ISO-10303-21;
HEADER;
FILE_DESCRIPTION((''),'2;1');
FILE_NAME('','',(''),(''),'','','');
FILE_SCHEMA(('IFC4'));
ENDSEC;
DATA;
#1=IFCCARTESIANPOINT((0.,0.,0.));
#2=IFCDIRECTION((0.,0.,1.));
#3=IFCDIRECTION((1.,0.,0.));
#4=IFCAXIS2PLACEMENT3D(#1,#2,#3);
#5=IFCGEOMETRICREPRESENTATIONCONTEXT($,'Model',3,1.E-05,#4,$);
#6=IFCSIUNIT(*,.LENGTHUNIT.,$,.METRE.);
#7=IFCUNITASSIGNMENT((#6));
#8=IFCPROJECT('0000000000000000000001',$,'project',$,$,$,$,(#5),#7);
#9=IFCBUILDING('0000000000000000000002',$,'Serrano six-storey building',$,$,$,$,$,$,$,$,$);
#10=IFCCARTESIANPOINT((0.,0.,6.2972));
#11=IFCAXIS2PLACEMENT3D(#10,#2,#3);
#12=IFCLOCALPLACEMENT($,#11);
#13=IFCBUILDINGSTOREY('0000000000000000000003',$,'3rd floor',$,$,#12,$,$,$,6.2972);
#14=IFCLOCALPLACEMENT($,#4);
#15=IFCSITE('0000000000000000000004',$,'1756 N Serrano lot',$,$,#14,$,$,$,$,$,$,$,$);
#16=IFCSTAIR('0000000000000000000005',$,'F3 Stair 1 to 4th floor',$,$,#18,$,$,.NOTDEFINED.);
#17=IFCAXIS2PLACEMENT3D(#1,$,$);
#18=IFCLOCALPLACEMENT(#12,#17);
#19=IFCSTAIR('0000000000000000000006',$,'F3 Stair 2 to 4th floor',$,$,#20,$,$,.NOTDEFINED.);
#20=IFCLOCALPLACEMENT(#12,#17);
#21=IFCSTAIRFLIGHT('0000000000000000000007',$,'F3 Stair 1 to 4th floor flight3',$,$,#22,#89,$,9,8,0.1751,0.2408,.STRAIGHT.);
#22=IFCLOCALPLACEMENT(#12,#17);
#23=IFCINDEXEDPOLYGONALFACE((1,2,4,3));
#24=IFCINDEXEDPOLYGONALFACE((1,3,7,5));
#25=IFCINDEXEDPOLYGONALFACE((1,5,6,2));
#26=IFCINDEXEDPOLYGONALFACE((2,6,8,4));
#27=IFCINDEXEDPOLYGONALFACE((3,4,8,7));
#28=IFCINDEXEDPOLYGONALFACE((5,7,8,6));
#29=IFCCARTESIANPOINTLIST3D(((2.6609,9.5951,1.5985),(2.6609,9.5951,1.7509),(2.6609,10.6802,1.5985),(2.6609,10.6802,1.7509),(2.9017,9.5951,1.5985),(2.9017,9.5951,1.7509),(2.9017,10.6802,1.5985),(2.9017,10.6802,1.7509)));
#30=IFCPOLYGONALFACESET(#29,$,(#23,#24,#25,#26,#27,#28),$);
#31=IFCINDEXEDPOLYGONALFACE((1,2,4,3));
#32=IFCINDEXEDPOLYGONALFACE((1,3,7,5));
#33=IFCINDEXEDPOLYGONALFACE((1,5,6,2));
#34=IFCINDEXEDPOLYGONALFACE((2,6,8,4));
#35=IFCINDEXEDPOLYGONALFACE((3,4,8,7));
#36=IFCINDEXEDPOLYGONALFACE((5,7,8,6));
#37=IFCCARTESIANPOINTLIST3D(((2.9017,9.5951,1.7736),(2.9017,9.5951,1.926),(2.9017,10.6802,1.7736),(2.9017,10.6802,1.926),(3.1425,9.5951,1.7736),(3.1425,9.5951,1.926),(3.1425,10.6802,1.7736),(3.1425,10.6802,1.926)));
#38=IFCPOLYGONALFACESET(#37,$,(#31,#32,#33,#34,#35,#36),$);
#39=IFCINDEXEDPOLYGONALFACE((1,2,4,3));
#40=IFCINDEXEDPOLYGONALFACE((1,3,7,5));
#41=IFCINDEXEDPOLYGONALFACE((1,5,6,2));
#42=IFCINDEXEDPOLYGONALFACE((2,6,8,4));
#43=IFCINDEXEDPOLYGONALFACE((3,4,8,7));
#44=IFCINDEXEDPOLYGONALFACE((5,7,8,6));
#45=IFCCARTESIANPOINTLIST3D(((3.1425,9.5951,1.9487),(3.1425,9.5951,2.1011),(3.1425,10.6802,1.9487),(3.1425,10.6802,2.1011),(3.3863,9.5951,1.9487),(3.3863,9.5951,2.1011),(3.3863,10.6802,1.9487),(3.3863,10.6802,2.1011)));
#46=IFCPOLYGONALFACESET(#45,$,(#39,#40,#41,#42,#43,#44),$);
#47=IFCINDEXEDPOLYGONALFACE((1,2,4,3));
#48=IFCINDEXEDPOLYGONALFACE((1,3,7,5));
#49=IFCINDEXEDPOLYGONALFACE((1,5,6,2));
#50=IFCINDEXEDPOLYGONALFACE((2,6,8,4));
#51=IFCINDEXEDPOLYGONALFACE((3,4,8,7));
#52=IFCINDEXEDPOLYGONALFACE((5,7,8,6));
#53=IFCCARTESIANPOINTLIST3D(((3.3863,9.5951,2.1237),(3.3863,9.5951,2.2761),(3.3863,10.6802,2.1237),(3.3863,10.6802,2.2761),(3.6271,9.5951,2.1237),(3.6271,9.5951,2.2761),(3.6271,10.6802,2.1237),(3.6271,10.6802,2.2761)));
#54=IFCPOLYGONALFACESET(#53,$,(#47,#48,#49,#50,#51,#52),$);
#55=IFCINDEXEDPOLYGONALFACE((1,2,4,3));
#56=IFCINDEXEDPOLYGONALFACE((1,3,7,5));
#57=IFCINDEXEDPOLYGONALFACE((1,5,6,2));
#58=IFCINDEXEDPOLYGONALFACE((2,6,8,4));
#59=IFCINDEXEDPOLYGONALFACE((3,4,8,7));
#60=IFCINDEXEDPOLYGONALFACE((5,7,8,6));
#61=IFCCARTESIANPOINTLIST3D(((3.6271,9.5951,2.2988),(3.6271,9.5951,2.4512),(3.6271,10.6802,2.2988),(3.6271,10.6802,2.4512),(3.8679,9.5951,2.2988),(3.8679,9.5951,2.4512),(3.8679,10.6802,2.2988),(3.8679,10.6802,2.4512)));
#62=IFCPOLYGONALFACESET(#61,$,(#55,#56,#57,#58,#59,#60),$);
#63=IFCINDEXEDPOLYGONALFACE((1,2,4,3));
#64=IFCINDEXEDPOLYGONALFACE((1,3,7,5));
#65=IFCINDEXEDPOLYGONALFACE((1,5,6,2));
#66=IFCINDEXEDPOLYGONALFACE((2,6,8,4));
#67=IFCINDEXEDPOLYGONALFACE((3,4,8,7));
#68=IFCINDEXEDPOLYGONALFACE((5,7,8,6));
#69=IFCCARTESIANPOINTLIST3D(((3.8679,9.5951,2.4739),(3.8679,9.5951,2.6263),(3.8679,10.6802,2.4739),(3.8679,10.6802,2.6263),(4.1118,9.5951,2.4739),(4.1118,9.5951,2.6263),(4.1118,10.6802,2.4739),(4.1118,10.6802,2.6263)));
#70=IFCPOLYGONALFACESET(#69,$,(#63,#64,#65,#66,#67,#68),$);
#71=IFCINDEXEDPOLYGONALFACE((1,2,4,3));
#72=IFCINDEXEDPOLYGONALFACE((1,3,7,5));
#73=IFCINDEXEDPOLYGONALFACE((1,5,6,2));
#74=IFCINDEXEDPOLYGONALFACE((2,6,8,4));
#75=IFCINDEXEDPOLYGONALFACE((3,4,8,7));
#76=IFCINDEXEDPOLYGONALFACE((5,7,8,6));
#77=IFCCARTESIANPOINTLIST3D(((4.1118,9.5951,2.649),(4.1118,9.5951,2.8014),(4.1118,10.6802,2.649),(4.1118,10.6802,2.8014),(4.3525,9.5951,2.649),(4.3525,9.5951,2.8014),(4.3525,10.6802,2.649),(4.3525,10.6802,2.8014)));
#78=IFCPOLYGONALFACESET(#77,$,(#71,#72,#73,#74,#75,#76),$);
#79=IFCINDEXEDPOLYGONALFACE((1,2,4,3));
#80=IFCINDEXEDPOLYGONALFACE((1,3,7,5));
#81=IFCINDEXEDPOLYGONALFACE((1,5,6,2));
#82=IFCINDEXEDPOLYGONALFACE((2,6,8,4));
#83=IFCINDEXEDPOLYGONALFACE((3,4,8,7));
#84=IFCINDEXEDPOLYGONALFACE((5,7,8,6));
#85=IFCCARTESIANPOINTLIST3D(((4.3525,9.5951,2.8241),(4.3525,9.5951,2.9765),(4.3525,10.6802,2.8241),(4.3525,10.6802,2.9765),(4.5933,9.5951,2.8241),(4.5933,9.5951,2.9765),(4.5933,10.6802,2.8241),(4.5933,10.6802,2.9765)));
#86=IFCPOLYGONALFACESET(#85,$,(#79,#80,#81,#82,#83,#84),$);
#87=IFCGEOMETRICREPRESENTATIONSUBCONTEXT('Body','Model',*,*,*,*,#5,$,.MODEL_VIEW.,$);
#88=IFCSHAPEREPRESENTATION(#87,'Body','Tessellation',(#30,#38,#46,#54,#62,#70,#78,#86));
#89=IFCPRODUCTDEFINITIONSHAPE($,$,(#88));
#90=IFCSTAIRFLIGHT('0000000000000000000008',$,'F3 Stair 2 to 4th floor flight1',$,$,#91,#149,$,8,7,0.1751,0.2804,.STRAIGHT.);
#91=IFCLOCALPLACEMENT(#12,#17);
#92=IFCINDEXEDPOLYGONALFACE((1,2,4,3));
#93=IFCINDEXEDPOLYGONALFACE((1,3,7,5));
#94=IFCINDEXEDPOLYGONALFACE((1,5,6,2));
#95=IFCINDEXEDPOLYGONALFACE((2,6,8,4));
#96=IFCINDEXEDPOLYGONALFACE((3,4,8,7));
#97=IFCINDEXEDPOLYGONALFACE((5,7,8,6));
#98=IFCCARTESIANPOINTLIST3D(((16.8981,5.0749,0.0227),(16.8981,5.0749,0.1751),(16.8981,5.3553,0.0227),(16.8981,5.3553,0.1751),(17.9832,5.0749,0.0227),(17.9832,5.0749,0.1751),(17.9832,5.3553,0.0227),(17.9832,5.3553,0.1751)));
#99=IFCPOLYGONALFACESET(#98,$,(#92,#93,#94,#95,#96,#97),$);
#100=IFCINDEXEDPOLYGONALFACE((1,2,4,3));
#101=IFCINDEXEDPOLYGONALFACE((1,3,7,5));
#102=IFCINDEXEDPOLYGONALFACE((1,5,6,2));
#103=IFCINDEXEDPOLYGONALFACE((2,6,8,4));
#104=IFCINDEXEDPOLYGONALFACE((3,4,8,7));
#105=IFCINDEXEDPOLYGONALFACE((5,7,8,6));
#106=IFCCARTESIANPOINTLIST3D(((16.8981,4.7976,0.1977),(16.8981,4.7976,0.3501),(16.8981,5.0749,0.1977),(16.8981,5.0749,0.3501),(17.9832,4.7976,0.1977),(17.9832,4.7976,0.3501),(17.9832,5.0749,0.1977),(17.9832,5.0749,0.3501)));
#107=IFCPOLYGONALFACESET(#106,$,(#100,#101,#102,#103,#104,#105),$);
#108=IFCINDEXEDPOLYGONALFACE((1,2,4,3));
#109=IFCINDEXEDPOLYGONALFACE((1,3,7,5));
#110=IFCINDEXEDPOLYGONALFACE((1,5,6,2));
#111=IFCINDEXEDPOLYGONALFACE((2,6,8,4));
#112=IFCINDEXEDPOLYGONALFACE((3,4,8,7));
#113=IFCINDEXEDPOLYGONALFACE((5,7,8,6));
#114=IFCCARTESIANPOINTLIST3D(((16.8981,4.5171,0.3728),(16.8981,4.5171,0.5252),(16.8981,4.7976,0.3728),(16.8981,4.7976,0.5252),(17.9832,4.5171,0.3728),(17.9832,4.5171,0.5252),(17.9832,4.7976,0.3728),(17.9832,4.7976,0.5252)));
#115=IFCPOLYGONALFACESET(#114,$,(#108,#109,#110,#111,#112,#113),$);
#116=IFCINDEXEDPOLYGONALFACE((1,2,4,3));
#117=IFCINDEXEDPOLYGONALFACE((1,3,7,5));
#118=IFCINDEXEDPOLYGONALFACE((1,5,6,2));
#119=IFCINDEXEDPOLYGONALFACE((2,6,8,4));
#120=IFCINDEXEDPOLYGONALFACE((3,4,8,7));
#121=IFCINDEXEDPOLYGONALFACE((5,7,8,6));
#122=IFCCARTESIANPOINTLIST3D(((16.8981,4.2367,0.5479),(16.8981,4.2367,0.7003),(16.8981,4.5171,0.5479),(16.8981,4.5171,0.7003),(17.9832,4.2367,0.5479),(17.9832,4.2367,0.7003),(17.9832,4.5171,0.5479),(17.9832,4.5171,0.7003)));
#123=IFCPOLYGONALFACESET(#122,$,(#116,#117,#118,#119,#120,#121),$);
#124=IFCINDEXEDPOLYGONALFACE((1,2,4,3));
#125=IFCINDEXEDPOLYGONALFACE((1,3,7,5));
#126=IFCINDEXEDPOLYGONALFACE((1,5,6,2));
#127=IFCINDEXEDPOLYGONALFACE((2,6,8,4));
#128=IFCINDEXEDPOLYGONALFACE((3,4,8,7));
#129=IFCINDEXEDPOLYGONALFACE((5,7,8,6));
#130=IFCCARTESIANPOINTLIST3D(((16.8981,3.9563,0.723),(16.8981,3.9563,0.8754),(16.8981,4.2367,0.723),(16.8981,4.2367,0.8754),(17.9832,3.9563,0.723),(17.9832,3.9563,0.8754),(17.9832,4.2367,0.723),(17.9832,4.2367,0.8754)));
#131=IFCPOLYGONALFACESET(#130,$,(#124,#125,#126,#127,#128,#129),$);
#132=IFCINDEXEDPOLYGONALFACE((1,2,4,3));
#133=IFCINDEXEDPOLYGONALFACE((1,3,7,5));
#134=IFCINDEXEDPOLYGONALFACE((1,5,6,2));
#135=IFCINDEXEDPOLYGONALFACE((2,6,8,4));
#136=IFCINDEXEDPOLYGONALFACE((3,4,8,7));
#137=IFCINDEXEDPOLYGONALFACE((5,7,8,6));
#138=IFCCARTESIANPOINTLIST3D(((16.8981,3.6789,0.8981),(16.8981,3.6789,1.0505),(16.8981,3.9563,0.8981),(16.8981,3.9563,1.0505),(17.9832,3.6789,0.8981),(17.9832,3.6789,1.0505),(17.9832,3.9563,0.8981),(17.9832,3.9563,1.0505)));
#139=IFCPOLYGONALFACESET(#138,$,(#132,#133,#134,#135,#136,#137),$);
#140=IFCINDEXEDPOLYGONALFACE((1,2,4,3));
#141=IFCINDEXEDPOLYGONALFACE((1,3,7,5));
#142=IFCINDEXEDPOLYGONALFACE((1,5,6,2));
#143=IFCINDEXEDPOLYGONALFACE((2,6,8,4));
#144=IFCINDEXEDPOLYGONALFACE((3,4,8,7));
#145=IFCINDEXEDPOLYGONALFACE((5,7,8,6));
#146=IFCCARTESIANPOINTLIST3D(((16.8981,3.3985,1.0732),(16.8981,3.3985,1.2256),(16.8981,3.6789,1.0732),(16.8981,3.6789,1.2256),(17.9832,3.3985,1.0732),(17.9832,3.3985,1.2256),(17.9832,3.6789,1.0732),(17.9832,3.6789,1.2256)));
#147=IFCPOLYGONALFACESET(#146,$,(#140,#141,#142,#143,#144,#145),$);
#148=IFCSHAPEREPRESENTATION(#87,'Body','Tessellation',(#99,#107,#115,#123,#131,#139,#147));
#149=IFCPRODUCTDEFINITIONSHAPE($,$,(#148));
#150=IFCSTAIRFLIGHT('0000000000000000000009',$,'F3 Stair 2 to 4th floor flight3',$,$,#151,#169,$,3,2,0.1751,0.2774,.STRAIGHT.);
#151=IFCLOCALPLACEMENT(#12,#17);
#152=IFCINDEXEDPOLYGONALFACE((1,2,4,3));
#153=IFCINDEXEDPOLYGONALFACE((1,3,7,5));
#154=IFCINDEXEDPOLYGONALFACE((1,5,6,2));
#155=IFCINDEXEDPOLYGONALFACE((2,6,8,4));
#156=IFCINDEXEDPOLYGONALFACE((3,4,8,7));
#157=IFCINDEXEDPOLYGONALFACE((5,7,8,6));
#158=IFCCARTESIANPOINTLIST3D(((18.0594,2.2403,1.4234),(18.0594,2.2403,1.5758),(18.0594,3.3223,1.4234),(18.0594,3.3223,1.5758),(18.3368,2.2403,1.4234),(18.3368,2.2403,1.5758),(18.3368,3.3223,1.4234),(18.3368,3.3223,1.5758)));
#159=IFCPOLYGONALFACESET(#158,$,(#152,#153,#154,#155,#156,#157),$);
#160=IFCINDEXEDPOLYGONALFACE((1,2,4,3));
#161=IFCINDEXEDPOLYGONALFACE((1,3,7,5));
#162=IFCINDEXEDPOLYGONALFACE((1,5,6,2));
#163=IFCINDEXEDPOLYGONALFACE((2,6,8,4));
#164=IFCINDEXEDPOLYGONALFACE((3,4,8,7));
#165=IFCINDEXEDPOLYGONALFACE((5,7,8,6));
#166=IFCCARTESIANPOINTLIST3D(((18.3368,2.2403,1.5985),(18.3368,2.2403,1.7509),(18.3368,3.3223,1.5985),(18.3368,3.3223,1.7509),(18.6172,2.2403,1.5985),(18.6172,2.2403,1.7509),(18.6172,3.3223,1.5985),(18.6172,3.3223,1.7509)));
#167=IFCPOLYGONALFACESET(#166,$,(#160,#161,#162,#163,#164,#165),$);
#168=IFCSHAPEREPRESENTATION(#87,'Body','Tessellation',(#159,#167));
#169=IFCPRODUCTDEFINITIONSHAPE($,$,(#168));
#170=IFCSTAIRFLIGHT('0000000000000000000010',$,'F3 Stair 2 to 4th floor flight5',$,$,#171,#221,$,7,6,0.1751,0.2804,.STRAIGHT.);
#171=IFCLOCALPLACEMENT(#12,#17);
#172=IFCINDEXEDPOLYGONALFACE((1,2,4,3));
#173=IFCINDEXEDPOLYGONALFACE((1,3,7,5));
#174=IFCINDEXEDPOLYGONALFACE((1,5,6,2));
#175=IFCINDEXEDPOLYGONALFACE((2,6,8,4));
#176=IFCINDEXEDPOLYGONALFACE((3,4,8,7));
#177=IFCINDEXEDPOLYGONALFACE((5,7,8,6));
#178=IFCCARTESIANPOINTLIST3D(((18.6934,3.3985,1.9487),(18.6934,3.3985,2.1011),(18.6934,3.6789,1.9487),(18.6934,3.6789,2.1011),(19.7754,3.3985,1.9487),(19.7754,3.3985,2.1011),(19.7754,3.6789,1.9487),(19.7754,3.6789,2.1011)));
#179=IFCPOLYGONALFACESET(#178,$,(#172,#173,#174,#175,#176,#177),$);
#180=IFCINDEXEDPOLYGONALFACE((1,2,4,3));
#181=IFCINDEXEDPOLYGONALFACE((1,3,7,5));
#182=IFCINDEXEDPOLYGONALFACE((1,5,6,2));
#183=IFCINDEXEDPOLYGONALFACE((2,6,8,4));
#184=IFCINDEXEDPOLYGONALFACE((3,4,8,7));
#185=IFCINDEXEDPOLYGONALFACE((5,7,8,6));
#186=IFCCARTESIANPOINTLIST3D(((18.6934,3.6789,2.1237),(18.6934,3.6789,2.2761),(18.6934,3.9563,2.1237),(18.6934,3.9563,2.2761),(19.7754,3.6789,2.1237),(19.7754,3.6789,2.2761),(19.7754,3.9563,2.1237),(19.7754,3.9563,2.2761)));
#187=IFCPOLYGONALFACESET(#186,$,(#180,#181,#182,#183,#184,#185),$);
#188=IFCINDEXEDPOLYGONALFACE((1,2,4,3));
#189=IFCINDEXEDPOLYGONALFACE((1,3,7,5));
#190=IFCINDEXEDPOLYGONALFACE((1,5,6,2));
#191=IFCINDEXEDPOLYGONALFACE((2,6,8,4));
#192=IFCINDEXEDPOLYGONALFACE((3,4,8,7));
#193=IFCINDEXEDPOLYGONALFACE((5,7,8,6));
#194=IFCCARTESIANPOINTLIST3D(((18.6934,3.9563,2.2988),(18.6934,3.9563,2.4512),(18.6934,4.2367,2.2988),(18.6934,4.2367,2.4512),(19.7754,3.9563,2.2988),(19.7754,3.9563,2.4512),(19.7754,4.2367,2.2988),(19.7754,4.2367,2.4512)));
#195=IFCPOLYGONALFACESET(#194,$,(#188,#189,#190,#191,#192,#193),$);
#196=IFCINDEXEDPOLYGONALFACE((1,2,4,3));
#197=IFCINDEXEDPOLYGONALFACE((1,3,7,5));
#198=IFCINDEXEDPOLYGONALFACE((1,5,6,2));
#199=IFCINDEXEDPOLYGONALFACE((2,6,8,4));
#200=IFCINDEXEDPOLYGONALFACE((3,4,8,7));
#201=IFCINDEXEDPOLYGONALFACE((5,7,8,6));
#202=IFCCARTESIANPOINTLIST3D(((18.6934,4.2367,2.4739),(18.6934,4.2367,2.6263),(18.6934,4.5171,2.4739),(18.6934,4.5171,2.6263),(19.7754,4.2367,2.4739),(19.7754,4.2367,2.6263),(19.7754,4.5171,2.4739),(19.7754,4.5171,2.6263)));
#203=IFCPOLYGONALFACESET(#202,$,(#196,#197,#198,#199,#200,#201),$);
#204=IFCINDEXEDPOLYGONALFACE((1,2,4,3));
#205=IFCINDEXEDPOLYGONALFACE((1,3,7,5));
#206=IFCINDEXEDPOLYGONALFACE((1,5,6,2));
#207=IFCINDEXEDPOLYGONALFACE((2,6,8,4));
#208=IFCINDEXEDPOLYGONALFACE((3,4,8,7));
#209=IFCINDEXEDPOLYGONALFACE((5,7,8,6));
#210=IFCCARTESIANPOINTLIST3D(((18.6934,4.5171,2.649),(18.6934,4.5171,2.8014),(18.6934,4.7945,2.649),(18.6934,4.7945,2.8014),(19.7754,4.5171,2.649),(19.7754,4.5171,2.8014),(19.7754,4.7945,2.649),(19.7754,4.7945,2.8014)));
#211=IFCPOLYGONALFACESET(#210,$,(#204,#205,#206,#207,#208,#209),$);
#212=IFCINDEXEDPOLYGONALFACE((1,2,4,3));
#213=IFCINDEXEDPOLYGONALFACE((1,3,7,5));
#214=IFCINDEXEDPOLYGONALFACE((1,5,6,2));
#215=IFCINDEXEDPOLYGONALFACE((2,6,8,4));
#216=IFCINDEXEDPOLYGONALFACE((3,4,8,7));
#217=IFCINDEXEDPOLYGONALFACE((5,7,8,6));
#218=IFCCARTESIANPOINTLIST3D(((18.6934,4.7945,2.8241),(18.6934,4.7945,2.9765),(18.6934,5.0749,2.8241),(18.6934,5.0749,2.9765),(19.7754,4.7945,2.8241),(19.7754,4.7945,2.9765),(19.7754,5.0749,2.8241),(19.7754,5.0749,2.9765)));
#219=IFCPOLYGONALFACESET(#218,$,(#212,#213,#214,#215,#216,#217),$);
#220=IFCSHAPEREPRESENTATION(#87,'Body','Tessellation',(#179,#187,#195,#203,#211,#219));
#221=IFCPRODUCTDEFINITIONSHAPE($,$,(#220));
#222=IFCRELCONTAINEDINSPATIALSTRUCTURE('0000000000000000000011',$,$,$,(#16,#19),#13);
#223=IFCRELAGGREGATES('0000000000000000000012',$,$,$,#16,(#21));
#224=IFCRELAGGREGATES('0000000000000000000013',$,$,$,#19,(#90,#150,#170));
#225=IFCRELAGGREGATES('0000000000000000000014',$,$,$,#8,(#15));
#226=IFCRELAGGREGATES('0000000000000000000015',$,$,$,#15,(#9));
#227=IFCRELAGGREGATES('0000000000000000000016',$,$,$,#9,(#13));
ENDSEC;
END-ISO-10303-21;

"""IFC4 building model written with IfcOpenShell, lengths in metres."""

from ifc_helpers import new_model, si_unit, frame, origin_with_axes, place, context, subcontext, project, spatial, polyline, outline, extrude, element, aggregate, save


model = new_model("IFC4")

# Units and contexts
model_context = context("Model", 3, precision=1e-05, world=origin_with_axes())
body_context = subcontext(model_context, "Body", "Model", "MODEL_VIEW")
ifc_project = project(units=[si_unit("LENGTHUNIT", "METRE")], contexts=[model_context])

# Site, building, storey
site_placement = place(None, origin_with_axes())
site = spatial("IfcSite", under=ifc_project, at=site_placement, Name="1756 N Serrano lot")
building = spatial("IfcBuilding", under=site, Name="Serrano six-storey building")
storey_placement = place(None, frame((0.0, 0.0, 6.2972), z_axis=(0.0, 0.0, 1.0), x_axis=(1.0, 0.0, 0.0)))
storey = spatial("IfcBuildingStorey", under=building, at=storey_placement, Name="3rd floor", Elevation=6.2972)

# Stair
stair_1 = element("IfcStair", 1, inside=storey, Name="F3 Stair 1 to 4th floor", PredefinedType="NOTDEFINED")

# Stair
stair_2 = element("IfcStair", 2, inside=storey, Name="F3 Stair 2 to 4th floor", PredefinedType="NOTDEFINED")

# Stair flights
stair_flight_1_placement = place(None, origin_with_axes())
stair_flight_1 = element("IfcStairFlight", 3, at=stair_flight_1_placement, Name="F3 Stair 1 to 4th floor flight3", NumberOfRisers=9, NumberOfTreads=8, PredefinedType="STRAIGHT", RiserHeight=0.1751, TreadLength=0.2408, context=body_context, shape_type="SweptSolid", body=[
    extrude(outline(polyline([(2.9017, 9.5951), (2.9017, 10.6802), (2.6609, 10.6802), (2.6609, 9.5951), (2.9017, 9.5951)])), frame((0.0, 0.0, 7.8957)), (0.0, 0.0, 1.0), 0.1524),
    extrude(outline(polyline([(3.1425, 9.5951), (3.1425, 10.6802), (2.9017, 10.6802), (2.9017, 9.5951), (3.1425, 9.5951)])), frame((0.0, 0.0, 8.0708)), (0.0, 0.0, 1.0), 0.1524),
    extrude(outline(polyline([(3.3863, 9.5951), (3.3863, 10.6802), (3.1425, 10.6802), (3.1425, 9.5951), (3.3863, 9.5951)])), frame((0.0, 0.0, 8.2459)), (0.0, 0.0, 1.0), 0.1524),
    extrude(outline(polyline([(3.6271, 9.5951), (3.6271, 10.6802), (3.3863, 10.6802), (3.3863, 9.5951), (3.6271, 9.5951)])), frame((0.0, 0.0, 8.4209)), (0.0, 0.0, 1.0), 0.1524),
    extrude(outline(polyline([(3.8679, 9.5951), (3.8679, 10.6802), (3.6271, 10.6802), (3.6271, 9.5951), (3.8679, 9.5951)])), frame((0.0, 0.0, 8.596)), (0.0, 0.0, 1.0), 0.1524),
    extrude(outline(polyline([(4.1118, 9.5951), (4.1118, 10.6802), (3.8679, 10.6802), (3.8679, 9.5951), (4.1118, 9.5951)])), frame((0.0, 0.0, 8.7711)), (0.0, 0.0, 1.0), 0.1524),
    extrude(outline(polyline([(4.3525, 9.5951), (4.3525, 10.6802), (4.1118, 10.6802), (4.1118, 9.5951), (4.3525, 9.5951)])), frame((0.0, 0.0, 8.9462)), (0.0, 0.0, 1.0), 0.1524),
    extrude(outline(polyline([(4.5933, 9.5951), (4.5933, 10.6802), (4.3525, 10.6802), (4.3525, 9.5951), (4.5933, 9.5951)])), frame((0.0, 0.0, 9.1213)), (0.0, 0.0, 1.0), 0.1524),
])
aggregate(stair_1, [stair_flight_1])
stair_flight_2_placement = place(None, origin_with_axes())
stair_flight_2 = element("IfcStairFlight", 4, at=stair_flight_2_placement, Name="F3 Stair 2 to 4th floor flight1", NumberOfRisers=8, NumberOfTreads=7, PredefinedType="STRAIGHT", RiserHeight=0.1751, TreadLength=0.2804, context=body_context, shape_type="SweptSolid", body=[
    extrude(outline(polyline([(17.9832, 5.0749), (17.9832, 5.3553), (16.8981, 5.3553), (16.8981, 5.0749), (17.9832, 5.0749)])), frame((0.0, 0.0, 6.3199)), (0.0, 0.0, 1.0), 0.1524),
    extrude(outline(polyline([(17.9832, 4.7976), (17.9832, 5.0749), (16.8981, 5.0749), (16.8981, 4.7976), (17.9832, 4.7976)])), frame((0.0, 0.0, 6.4949)), (0.0, 0.0, 1.0), 0.1524),
    extrude(outline(polyline([(17.9832, 4.5171), (17.9832, 4.7976), (16.8981, 4.7976), (16.8981, 4.5171), (17.9832, 4.5171)])), frame((0.0, 0.0, 6.67)), (0.0, 0.0, 1.0), 0.1524),
    extrude(outline(polyline([(17.9832, 4.2367), (17.9832, 4.5171), (16.8981, 4.5171), (16.8981, 4.2367), (17.9832, 4.2367)])), frame((0.0, 0.0, 6.8451)), (0.0, 0.0, 1.0), 0.1524),
    extrude(outline(polyline([(17.9832, 3.9563), (17.9832, 4.2367), (16.8981, 4.2367), (16.8981, 3.9563), (17.9832, 3.9563)])), frame((0.0, 0.0, 7.0202)), (0.0, 0.0, 1.0), 0.1524),
    extrude(outline(polyline([(17.9832, 3.6789), (17.9832, 3.9563), (16.8981, 3.9563), (16.8981, 3.6789), (17.9832, 3.6789)])), frame((0.0, 0.0, 7.1953)), (0.0, 0.0, 1.0), 0.1524),
    extrude(outline(polyline([(17.9832, 3.3985), (17.9832, 3.6789), (16.8981, 3.6789), (16.8981, 3.3985), (17.9832, 3.3985)])), frame((0.0, 0.0, 7.3704)), (0.0, 0.0, 1.0), 0.1524),
])
stair_flight_3_placement = place(None, origin_with_axes())
stair_flight_3 = element("IfcStairFlight", 5, at=stair_flight_3_placement, Name="F3 Stair 2 to 4th floor flight3", NumberOfRisers=3, NumberOfTreads=2, PredefinedType="STRAIGHT", RiserHeight=0.1751, TreadLength=0.2774, context=body_context, shape_type="SweptSolid", body=[
    extrude(outline(polyline([(18.3368, 2.2403), (18.3368, 3.3223), (18.0594, 3.3223), (18.0594, 2.2403), (18.3368, 2.2403)])), frame((0.0, 0.0, 7.7206)), (0.0, 0.0, 1.0), 0.1524),
    extrude(outline(polyline([(18.6172, 2.2403), (18.6172, 3.3223), (18.3368, 3.3223), (18.3368, 2.2403), (18.6172, 2.2403)])), frame((0.0, 0.0, 7.8957)), (0.0, 0.0, 1.0), 0.1524),
])
stair_flight_4_placement = place(None, origin_with_axes())
stair_flight_4 = element("IfcStairFlight", 6, at=stair_flight_4_placement, Name="F3 Stair 2 to 4th floor flight5", NumberOfRisers=7, NumberOfTreads=6, PredefinedType="STRAIGHT", RiserHeight=0.1751, TreadLength=0.2804, context=body_context, shape_type="SweptSolid", body=[
    extrude(outline(polyline([(19.7754, 3.3985), (19.7754, 3.6789), (18.6934, 3.6789), (18.6934, 3.3985), (19.7754, 3.3985)])), frame((0.0, 0.0, 8.2459)), (0.0, 0.0, 1.0), 0.1524),
    extrude(outline(polyline([(19.7754, 3.6789), (19.7754, 3.9563), (18.6934, 3.9563), (18.6934, 3.6789), (19.7754, 3.6789)])), frame((0.0, 0.0, 8.4209)), (0.0, 0.0, 1.0), 0.1524),
    extrude(outline(polyline([(19.7754, 3.9563), (19.7754, 4.2367), (18.6934, 4.2367), (18.6934, 3.9563), (19.7754, 3.9563)])), frame((0.0, 0.0, 8.596)), (0.0, 0.0, 1.0), 0.1524),
    extrude(outline(polyline([(19.7754, 4.2367), (19.7754, 4.5171), (18.6934, 4.5171), (18.6934, 4.2367), (19.7754, 4.2367)])), frame((0.0, 0.0, 8.7711)), (0.0, 0.0, 1.0), 0.1524),
    extrude(outline(polyline([(19.7754, 4.5171), (19.7754, 4.7945), (18.6934, 4.7945), (18.6934, 4.5171), (19.7754, 4.5171)])), frame((0.0, 0.0, 8.9462)), (0.0, 0.0, 1.0), 0.1524),
    extrude(outline(polyline([(19.7754, 4.7945), (19.7754, 5.0749), (18.6934, 5.0749), (18.6934, 4.7945), (19.7754, 4.7945)])), frame((0.0, 0.0, 9.1213)), (0.0, 0.0, 1.0), 0.1524),
])
aggregate(stair_2, [stair_flight_2, stair_flight_3, stair_flight_4])

save(model, "model.ifc")
